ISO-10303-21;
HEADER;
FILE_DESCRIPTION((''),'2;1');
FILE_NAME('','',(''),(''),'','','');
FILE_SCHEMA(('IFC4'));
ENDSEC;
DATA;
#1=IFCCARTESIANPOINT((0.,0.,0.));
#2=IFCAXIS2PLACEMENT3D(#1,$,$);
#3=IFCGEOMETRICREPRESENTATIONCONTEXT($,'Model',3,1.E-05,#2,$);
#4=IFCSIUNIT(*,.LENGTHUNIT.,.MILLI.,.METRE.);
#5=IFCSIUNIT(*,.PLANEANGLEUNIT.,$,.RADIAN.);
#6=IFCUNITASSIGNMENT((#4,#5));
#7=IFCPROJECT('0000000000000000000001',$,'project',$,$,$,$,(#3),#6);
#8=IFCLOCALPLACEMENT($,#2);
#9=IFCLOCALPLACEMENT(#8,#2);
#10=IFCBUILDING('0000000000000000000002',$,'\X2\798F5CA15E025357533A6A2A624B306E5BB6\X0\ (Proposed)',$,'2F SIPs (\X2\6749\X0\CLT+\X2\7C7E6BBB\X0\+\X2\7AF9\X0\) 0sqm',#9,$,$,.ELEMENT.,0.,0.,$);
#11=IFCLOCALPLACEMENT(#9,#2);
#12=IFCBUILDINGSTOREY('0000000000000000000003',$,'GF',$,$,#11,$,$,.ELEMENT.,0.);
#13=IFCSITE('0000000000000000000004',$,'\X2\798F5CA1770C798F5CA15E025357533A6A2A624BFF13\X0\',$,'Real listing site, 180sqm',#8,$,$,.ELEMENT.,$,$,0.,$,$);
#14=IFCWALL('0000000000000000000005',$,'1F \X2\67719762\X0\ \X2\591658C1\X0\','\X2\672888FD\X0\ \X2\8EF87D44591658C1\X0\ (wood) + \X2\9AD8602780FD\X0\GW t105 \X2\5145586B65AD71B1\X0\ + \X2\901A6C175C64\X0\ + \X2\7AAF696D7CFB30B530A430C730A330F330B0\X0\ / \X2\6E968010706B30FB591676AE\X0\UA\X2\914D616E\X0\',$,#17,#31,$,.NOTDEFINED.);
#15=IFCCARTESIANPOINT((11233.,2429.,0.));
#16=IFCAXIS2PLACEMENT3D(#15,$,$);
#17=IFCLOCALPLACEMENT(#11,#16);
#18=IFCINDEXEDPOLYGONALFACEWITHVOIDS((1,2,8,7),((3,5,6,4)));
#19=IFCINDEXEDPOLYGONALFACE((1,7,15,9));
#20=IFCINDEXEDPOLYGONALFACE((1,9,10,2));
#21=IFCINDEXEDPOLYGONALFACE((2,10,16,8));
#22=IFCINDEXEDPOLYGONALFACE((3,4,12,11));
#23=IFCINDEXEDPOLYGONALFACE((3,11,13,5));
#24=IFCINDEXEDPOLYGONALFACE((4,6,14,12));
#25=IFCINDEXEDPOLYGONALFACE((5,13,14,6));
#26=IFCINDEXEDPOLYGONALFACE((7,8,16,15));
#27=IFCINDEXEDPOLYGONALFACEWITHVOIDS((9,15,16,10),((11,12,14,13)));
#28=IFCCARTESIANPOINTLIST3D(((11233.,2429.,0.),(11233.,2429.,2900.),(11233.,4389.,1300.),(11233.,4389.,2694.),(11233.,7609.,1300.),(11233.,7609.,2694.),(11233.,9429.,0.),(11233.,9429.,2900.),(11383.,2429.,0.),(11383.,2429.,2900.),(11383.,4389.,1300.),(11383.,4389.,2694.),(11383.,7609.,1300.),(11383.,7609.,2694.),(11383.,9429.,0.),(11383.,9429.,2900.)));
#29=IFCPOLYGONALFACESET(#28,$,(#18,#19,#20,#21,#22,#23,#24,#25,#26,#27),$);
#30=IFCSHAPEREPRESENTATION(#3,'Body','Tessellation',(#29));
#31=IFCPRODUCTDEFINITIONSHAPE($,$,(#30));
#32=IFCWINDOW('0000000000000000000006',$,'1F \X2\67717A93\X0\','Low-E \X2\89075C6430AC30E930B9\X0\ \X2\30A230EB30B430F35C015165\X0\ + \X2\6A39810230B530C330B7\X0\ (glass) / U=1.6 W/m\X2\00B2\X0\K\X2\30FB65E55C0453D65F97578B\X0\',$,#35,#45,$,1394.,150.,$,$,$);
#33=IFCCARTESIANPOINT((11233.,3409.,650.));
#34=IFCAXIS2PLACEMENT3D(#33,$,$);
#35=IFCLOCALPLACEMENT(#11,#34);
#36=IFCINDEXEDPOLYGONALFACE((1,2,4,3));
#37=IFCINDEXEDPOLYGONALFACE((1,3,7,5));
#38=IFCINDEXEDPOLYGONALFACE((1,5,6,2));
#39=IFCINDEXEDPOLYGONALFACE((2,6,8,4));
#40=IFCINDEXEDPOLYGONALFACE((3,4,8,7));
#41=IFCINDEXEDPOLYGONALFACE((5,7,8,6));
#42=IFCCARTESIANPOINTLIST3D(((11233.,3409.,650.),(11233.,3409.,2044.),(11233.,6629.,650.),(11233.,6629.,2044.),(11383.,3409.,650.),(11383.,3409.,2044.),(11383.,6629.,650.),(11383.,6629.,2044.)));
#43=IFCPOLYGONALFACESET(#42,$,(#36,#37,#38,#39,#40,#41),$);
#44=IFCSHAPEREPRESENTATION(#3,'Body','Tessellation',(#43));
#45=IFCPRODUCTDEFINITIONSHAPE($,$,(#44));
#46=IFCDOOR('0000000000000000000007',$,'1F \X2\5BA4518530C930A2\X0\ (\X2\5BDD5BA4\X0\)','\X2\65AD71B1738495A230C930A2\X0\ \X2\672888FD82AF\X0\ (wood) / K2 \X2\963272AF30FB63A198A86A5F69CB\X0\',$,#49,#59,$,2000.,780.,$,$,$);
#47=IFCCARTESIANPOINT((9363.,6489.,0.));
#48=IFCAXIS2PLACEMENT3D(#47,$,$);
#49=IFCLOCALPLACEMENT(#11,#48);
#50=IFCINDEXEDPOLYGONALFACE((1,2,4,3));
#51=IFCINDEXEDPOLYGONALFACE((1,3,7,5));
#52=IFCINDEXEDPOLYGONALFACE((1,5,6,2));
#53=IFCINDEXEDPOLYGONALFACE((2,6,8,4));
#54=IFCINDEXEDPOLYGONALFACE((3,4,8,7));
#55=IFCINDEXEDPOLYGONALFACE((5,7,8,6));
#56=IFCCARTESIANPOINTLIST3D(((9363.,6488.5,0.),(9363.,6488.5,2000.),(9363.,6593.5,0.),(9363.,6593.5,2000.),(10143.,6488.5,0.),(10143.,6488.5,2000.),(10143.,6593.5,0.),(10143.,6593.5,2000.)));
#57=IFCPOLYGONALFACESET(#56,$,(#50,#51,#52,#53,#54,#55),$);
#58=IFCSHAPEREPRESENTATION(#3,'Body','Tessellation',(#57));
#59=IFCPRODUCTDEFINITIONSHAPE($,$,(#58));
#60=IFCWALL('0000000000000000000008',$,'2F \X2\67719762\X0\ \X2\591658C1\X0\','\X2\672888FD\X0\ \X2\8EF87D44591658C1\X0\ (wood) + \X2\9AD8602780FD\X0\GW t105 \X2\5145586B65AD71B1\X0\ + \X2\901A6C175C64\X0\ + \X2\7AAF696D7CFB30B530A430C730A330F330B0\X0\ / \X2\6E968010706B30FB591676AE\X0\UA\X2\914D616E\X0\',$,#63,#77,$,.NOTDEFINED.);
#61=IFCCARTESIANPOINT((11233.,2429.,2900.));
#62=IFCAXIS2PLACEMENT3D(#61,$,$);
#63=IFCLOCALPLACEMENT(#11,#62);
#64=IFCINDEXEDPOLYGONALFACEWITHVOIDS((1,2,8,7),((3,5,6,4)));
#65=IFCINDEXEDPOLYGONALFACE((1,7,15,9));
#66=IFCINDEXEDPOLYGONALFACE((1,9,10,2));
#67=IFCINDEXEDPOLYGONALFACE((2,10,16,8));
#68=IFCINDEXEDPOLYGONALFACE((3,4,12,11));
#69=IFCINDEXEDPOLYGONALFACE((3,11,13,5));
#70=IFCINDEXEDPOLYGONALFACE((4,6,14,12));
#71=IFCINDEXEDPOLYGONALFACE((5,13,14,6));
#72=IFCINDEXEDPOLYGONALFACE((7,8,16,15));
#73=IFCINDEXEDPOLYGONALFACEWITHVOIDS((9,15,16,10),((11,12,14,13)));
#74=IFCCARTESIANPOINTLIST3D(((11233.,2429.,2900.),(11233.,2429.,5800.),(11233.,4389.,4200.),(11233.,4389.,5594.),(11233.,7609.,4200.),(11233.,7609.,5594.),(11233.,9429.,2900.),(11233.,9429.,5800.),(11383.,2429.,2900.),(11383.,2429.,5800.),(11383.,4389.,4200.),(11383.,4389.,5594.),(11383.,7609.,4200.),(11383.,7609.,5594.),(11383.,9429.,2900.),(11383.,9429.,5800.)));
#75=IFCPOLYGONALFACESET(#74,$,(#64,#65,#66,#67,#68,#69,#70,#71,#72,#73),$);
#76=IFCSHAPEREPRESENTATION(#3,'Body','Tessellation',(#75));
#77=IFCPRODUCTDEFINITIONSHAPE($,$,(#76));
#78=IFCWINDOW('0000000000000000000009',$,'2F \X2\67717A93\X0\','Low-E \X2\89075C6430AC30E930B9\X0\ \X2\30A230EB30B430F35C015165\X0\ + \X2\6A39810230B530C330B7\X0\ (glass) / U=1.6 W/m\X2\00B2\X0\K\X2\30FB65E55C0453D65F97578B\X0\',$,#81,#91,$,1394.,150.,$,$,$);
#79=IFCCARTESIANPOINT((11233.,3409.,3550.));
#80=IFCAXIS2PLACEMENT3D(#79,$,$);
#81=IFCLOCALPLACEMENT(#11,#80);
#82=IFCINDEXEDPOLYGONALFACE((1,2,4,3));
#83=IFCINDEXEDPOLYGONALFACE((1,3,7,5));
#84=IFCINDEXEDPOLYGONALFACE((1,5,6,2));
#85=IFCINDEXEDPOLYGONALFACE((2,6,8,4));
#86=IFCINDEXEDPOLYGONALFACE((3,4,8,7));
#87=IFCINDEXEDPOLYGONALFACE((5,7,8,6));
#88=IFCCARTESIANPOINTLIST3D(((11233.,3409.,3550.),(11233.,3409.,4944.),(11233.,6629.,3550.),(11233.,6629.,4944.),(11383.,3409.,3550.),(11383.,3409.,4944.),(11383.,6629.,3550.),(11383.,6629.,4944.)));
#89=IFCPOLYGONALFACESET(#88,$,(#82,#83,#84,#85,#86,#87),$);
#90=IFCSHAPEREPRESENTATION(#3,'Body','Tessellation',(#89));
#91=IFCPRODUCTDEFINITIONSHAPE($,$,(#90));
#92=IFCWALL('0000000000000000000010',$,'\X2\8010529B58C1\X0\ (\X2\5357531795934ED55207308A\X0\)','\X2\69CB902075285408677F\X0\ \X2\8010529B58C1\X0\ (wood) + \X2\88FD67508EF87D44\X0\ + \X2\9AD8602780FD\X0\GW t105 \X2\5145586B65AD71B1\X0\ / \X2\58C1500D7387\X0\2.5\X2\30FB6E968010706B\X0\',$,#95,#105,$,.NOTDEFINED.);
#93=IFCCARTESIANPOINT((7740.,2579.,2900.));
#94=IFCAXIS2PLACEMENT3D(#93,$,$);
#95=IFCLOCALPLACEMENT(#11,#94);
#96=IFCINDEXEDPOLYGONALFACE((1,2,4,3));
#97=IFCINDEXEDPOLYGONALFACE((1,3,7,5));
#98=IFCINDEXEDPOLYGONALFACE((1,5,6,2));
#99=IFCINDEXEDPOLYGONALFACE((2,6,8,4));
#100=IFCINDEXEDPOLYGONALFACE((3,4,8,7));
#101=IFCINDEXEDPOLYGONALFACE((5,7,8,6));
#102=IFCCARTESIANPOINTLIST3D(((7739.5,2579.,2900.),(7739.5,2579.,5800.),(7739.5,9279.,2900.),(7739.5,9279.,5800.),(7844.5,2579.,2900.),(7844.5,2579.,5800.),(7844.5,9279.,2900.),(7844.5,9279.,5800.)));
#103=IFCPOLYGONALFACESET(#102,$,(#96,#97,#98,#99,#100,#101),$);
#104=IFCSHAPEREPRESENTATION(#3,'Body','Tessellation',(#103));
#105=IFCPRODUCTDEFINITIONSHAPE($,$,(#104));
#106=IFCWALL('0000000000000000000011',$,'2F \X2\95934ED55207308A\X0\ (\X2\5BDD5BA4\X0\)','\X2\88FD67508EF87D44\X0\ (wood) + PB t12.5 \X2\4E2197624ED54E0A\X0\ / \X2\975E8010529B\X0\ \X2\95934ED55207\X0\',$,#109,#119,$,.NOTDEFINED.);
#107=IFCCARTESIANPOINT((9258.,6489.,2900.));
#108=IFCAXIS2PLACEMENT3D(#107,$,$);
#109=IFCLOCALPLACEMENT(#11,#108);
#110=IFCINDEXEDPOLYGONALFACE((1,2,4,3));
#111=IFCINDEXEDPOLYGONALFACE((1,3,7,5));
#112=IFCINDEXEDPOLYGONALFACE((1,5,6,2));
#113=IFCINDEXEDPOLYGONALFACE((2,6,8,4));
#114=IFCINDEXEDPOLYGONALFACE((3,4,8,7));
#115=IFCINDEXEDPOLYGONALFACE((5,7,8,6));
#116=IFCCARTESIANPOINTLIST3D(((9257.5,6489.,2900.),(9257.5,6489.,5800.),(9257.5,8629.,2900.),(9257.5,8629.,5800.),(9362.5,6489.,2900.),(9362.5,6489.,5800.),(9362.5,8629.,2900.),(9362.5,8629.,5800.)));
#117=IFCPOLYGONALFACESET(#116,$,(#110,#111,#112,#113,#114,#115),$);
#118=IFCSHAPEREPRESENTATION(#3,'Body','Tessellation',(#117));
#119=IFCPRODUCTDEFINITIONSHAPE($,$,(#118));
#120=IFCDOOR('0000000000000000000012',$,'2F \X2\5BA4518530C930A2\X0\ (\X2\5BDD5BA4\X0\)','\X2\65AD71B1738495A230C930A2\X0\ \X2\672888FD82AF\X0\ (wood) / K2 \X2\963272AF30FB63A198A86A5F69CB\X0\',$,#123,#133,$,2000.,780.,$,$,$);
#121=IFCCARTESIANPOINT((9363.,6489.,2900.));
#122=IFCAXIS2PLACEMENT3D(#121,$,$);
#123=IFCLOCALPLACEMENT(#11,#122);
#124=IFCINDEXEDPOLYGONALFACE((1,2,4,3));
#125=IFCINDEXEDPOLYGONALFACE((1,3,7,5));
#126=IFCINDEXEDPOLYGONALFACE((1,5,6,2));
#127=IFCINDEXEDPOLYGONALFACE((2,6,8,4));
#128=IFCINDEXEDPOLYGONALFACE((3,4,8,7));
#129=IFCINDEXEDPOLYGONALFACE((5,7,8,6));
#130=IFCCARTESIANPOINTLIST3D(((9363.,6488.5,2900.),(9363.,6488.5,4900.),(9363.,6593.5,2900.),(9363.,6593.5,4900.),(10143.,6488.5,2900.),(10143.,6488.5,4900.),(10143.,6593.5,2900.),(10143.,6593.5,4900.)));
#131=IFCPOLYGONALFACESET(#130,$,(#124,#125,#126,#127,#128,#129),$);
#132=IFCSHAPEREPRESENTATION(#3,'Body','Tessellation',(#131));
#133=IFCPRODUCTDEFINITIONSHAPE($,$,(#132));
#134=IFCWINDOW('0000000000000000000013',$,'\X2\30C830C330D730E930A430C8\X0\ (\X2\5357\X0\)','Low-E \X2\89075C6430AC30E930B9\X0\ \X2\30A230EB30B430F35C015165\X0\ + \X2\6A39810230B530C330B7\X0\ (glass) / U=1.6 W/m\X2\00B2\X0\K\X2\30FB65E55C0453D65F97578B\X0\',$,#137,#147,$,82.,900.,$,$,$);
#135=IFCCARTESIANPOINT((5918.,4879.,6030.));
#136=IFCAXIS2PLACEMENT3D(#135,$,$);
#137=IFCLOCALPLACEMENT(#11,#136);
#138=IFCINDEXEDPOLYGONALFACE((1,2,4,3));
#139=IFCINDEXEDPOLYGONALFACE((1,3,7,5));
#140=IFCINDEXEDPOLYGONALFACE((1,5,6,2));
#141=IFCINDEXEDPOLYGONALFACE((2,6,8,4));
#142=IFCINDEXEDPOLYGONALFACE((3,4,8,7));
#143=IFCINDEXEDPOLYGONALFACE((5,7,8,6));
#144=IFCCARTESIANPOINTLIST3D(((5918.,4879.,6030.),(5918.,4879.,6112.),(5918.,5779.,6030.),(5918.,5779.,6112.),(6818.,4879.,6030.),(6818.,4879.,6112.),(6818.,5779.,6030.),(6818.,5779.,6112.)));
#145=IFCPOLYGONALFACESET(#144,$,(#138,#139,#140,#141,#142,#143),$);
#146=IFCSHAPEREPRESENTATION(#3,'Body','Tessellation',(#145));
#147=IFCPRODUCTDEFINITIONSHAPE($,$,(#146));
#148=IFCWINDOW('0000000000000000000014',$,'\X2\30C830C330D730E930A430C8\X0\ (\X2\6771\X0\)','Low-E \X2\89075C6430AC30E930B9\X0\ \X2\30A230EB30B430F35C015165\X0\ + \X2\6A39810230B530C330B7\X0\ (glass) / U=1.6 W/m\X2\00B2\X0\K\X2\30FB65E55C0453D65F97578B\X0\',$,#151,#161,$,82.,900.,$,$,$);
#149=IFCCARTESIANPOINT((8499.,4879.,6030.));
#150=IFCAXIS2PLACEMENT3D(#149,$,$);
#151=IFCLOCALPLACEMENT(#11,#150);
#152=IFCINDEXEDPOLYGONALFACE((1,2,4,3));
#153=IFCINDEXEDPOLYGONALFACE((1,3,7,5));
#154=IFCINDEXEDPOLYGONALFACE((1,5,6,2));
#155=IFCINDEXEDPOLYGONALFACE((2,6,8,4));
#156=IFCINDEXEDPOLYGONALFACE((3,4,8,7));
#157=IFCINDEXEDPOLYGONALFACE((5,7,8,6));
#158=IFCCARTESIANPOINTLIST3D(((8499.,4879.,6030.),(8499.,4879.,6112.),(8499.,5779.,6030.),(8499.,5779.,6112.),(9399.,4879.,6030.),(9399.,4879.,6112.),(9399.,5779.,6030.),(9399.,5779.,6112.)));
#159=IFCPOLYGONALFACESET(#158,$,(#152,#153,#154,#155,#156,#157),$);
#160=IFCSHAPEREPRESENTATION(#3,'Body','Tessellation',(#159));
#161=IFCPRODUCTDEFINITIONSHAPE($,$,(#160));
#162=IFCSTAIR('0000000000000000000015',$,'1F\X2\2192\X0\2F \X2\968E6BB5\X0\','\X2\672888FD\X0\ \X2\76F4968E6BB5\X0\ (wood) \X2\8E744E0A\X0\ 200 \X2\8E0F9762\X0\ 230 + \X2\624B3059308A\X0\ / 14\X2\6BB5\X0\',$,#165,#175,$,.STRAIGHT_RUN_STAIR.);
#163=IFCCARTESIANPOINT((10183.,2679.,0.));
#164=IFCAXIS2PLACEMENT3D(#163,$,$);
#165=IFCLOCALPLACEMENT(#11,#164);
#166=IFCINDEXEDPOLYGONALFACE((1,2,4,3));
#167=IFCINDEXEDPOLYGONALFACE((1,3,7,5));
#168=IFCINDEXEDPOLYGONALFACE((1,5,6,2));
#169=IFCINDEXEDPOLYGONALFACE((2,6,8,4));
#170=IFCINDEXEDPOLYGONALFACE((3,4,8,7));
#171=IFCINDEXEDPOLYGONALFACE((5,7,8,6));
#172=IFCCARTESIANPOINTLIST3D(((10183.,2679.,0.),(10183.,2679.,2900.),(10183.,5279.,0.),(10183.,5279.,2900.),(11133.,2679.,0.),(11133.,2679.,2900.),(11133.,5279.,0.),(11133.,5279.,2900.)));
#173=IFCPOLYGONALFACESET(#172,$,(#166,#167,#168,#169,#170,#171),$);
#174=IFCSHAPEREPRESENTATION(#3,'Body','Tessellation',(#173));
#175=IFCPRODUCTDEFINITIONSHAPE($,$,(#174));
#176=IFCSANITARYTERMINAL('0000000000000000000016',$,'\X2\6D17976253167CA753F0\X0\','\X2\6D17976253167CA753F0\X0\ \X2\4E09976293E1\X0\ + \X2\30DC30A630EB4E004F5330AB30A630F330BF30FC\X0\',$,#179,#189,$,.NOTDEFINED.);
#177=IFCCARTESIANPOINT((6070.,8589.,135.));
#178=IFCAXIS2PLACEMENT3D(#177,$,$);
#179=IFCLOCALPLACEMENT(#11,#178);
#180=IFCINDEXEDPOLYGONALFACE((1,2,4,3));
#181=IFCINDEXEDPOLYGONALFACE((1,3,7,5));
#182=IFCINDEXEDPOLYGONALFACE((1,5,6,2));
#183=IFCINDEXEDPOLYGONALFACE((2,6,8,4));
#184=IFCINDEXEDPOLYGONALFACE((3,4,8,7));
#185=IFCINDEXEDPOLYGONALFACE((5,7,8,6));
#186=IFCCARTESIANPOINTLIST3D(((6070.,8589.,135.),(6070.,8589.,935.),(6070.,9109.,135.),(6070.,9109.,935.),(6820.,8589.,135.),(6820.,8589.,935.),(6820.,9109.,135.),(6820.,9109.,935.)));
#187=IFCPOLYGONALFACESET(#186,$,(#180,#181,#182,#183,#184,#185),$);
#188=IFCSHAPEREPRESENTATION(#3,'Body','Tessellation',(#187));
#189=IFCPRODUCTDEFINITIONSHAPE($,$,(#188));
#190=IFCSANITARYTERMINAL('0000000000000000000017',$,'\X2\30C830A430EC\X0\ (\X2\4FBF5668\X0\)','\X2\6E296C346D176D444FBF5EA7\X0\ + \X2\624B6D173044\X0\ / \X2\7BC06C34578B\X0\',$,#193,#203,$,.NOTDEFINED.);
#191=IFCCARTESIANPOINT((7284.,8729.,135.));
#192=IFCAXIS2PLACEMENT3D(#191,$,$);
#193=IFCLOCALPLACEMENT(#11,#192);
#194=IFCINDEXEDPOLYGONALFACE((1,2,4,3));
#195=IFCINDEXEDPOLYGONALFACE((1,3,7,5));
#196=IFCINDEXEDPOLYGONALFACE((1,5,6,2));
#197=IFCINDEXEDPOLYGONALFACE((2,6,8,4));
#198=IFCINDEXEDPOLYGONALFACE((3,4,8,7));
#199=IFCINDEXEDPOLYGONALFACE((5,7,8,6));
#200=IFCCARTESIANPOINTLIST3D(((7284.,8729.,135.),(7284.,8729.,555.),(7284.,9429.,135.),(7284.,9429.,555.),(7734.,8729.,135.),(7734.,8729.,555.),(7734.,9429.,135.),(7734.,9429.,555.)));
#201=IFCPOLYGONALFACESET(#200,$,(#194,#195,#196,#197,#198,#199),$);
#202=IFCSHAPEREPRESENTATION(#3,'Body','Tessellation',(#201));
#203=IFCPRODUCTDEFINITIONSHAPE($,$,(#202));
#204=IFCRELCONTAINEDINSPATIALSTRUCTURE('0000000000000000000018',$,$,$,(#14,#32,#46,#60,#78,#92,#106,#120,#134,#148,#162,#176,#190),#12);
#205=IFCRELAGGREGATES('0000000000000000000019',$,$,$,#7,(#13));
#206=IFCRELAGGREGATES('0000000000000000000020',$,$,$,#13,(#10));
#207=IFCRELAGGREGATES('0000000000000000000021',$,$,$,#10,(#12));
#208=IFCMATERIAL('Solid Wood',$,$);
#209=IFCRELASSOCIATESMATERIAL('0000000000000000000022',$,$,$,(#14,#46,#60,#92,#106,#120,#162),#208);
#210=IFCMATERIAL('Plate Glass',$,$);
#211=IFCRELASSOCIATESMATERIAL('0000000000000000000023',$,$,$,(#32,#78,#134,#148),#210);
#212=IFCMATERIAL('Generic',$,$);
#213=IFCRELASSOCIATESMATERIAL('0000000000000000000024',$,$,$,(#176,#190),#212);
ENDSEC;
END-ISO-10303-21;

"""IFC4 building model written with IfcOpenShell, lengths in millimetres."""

from ifc_helpers import new_model, si_unit, frame, frame_2d, origin, place, context, project, spatial, rectangle, extrude, material, element, fill, save


model = new_model("IFC4")

# Units and contexts
model_context = context("Model", 3, precision=1e-05, world=origin())
ifc_project = project(units=[si_unit("LENGTHUNIT", "METRE", prefix="MILLI"), si_unit("PLANEANGLEUNIT", "RADIAN")], contexts=[model_context])

# Site, building, storey
site_placement = place(None, origin())
site = spatial("IfcSite", under=ifc_project, at=site_placement, Name="福岡県福岡市南区横手３", ObjectType="Real listing site, 180sqm", CompositionType="ELEMENT", RefElevation=0.0)
building_placement = place(site_placement, origin())
building = spatial("IfcBuilding", under=site, at=building_placement, Name="福岡市南区横手の家 (Proposed)", ObjectType="2F SIPs (杉CLT+籾殻+竹) 0sqm", CompositionType="ELEMENT", ElevationOfRefHeight=0.0, ElevationOfTerrain=0.0)
storey_placement = place(building_placement, origin())
storey = spatial("IfcBuildingStorey", under=building, at=storey_placement, Name="GF", CompositionType="ELEMENT", Elevation=0.0)

# Wall, opening, window
ifc_material_1 = material(Name="Solid Wood")
wall_1_placement = place(storey_placement, frame((11233.0, 2429.0, 0.0)))
wall_1 = element("IfcWall", 1, at=wall_1_placement, inside=storey, material=ifc_material_1, Name="1F 東面 外壁", Description="木製 軸組外壁 (wood) + 高性能GW t105 充填断熱 + 通気層 + 窯業系サイディング / 準耐火・外皮UA配慮", PredefinedType="NOTDEFINED", context=model_context, shape_type="SweptSolid", body=[
    extrude(rectangle(XDim=150.0, YDim=7000.0, at=frame_2d((75.0, 3500.0))), frame((11233.0, 2429.0, 0.0)), (0.0, 0.0, 1.0), 2900.0),
])
opening_1_placement = place(storey_placement, frame((11233.0, 3409.0, 650.0)))
opening_1 = element("IfcOpeningElement", 2, at=opening_1_placement, cuts=wall_1, PredefinedType="NOTDEFINED", context=model_context, shape_type="SweptSolid", body=[
    extrude(rectangle(XDim=150.0, YDim=3220.0, at=frame_2d((75.0, 1610.0))), frame((11233.0, 3409.0, 650.0)), (0.0, 0.0, 1.0), 1394.0),
])
ifc_material_2 = material(Name="Plate Glass")
window_1_placement = place(storey_placement, frame((11233.0, 3409.0, 650.0)))
window_1 = element("IfcWindow", 3, at=window_1_placement, inside=storey, material=ifc_material_2, Name="1F 東窓", Description="Low-E 複層ガラス アルゴン封入 + 樹脂サッシ (glass) / U=1.6 W/m²K・日射取得型", OverallHeight=1394.0, OverallWidth=150.0, context=model_context, shape_type="SweptSolid", body=[
    extrude(rectangle(XDim=150.0, YDim=3220.0, at=frame_2d((75.0, 1610.0))), frame((11233.0, 3409.0, 650.0)), (0.0, 0.0, 1.0), 1394.0),
])
fill(opening_1, window_1)

# Door
door_1_placement = place(storey_placement, frame((9363.0, 6489.0, 0.0)))
element("IfcDoor", 4, at=door_1_placement, inside=storey, material=ifc_material_1, Name="1F 室内ドア (寝室)", Description="断熱玄関ドア 木製芯 (wood) / K2 防犯・採風機構", OverallHeight=2000.0, OverallWidth=780.0, context=model_context, shape_type="SweptSolid", body=[
    extrude(rectangle(XDim=780.0, YDim=105.0, at=frame_2d((390.0, 52.0))), frame((9363.0, 6489.0, 0.0)), (0.0, 0.0, 1.0), 2000.0),
])

# Wall, opening, window
wall_2_placement = place(storey_placement, frame((11233.0, 2429.0, 2900.0)))
wall_2 = element("IfcWall", 5, at=wall_2_placement, inside=storey, material=ifc_material_1, Name="2F 東面 外壁", Description="木製 軸組外壁 (wood) + 高性能GW t105 充填断熱 + 通気層 + 窯業系サイディング / 準耐火・外皮UA配慮", PredefinedType="NOTDEFINED", context=model_context, shape_type="SweptSolid", body=[
    extrude(rectangle(XDim=150.0, YDim=7000.0, at=frame_2d((75.0, 3500.0))), frame((11233.0, 2429.0, 2900.0)), (0.0, 0.0, 1.0), 2900.0),
])
opening_2_placement = place(storey_placement, frame((11233.0, 3409.0, 3550.0)))
opening_2 = element("IfcOpeningElement", 6, at=opening_2_placement, cuts=wall_2, PredefinedType="NOTDEFINED", context=model_context, shape_type="SweptSolid", body=[
    extrude(rectangle(XDim=150.0, YDim=3220.0, at=frame_2d((75.0, 1610.0))), frame((11233.0, 3409.0, 3550.0)), (0.0, 0.0, 1.0), 1394.0),
])
window_2_placement = place(storey_placement, frame((11233.0, 3409.0, 3550.0)))
window_2 = element("IfcWindow", 7, at=window_2_placement, inside=storey, material=ifc_material_2, Name="2F 東窓", Description="Low-E 複層ガラス アルゴン封入 + 樹脂サッシ (glass) / U=1.6 W/m²K・日射取得型", OverallHeight=1394.0, OverallWidth=150.0, context=model_context, shape_type="SweptSolid", body=[
    extrude(rectangle(XDim=150.0, YDim=3220.0, at=frame_2d((75.0, 1610.0))), frame((11233.0, 3409.0, 3550.0)), (0.0, 0.0, 1.0), 1394.0),
])
fill(opening_2, window_2)

# Walls
wall_3_placement = place(storey_placement, frame((7740.0, 2579.0, 2900.0)))
element("IfcWall", 8, at=wall_3_placement, inside=storey, material=ifc_material_1, Name="耐力壁 (南北間仕切り)", Description="構造用合板 耐力壁 (wood) + 製材軸組 + 高性能GW t105 充填断熱 / 壁倍率2.5・準耐火", PredefinedType="NOTDEFINED", context=model_context, shape_type="SweptSolid", body=[
    extrude(rectangle(XDim=105.0, YDim=6700.0, at=frame_2d((52.0, 3350.0))), frame((7740.0, 2579.0, 2900.0)), (0.0, 0.0, 1.0), 2900.0),
])
wall_4_placement = place(storey_placement, frame((9258.0, 6489.0, 2900.0)))
element("IfcWall", 9, at=wall_4_placement, inside=storey, material=ifc_material_1, Name="2F 間仕切り (寝室)", Description="製材軸組 (wood) + PB t12.5 両面仕上 / 非耐力 間仕切", PredefinedType="NOTDEFINED", context=model_context, shape_type="SweptSolid", body=[
    extrude(rectangle(XDim=105.0, YDim=2140.0, at=frame_2d((52.0, 1070.0))), frame((9258.0, 6489.0, 2900.0)), (0.0, 0.0, 1.0), 2900.0),
])

# Door
door_2_placement = place(storey_placement, frame((9363.0, 6489.0, 2900.0)))
element("IfcDoor", 10, at=door_2_placement, inside=storey, material=ifc_material_1, Name="2F 室内ドア (寝室)", Description="断熱玄関ドア 木製芯 (wood) / K2 防犯・採風機構", OverallHeight=2000.0, OverallWidth=780.0, context=model_context, shape_type="SweptSolid", body=[
    extrude(rectangle(XDim=780.0, YDim=105.0, at=frame_2d((390.0, 52.0))), frame((9363.0, 6489.0, 2900.0)), (0.0, 0.0, 1.0), 2000.0),
])

# Windows
window_3_placement = place(storey_placement, frame((5918.0, 4879.0, 6030.0)))
element("IfcWindow", 11, at=window_3_placement, inside=storey, material=ifc_material_2, Name="トップライト (南)", Description="Low-E 複層ガラス アルゴン封入 + 樹脂サッシ (glass) / U=1.6 W/m²K・日射取得型", OverallHeight=82.0, OverallWidth=900.0, context=model_context, shape_type="SweptSolid", body=[
    extrude(rectangle(XDim=900.0, YDim=900.0, at=frame_2d((450.0, 450.0))), frame((5918.0, 4879.0, 6030.0)), (0.0, 0.0, 1.0), 82.0),
])
window_4_placement = place(storey_placement, frame((8499.0, 4879.0, 6030.0)))
element("IfcWindow", 12, at=window_4_placement, inside=storey, material=ifc_material_2, Name="トップライト (東)", Description="Low-E 複層ガラス アルゴン封入 + 樹脂サッシ (glass) / U=1.6 W/m²K・日射取得型", OverallHeight=82.0, OverallWidth=900.0, context=model_context, shape_type="SweptSolid", body=[
    extrude(rectangle(XDim=900.0, YDim=900.0, at=frame_2d((450.0, 450.0))), frame((8499.0, 4879.0, 6030.0)), (0.0, 0.0, 1.0), 82.0),
])

# Stair
stair_placement = place(storey_placement, frame((10183.0, 2679.0, 0.0)))
element("IfcStair", 13, at=stair_placement, inside=storey, material=ifc_material_1, Name="1F→2F 階段", Description="木製 直階段 (wood) 蹴上 200 踏面 230 + 手すり / 14段", PredefinedType="STRAIGHT_RUN_STAIR", context=model_context, shape_type="SweptSolid", body=[
    extrude(rectangle(XDim=950.0, YDim=2600.0, at=frame_2d((475.0, 1300.0))), frame((10183.0, 2679.0, 0.0)), (0.0, 0.0, 1.0), 2900.0),
])

# Sanitary terminals
ifc_material_3 = material(Name="Generic")
sanitary_terminal_1_placement = place(storey_placement, frame((6070.0, 8589.0, 135.0)))
element("IfcSanitaryTerminal", 14, at=sanitary_terminal_1_placement, inside=storey, material=ifc_material_3, Name="洗面化粧台", Description="洗面化粧台 三面鏡 + ボウル一体カウンター", PredefinedType="NOTDEFINED", context=model_context, shape_type="SweptSolid", body=[
    extrude(rectangle(XDim=750.0, YDim=520.0, at=frame_2d((375.0, 260.0))), frame((6070.0, 8589.0, 135.0)), (0.0, 0.0, 1.0), 800.0),
])
sanitary_terminal_2_placement = place(storey_placement, frame((7284.0, 8729.0, 135.0)))
element("IfcSanitaryTerminal", 15, at=sanitary_terminal_2_placement, inside=storey, material=ifc_material_3, Name="トイレ (便器)", Description="温水洗浄便座 + 手洗い / 節水型", PredefinedType="NOTDEFINED", context=model_context, shape_type="SweptSolid", body=[
    extrude(rectangle(XDim=450.0, YDim=700.0, at=frame_2d((225.0, 350.0))), frame((7284.0, 8729.0, 135.0)), (0.0, 0.0, 1.0), 420.0),
])

save(model, "model.ifc")
